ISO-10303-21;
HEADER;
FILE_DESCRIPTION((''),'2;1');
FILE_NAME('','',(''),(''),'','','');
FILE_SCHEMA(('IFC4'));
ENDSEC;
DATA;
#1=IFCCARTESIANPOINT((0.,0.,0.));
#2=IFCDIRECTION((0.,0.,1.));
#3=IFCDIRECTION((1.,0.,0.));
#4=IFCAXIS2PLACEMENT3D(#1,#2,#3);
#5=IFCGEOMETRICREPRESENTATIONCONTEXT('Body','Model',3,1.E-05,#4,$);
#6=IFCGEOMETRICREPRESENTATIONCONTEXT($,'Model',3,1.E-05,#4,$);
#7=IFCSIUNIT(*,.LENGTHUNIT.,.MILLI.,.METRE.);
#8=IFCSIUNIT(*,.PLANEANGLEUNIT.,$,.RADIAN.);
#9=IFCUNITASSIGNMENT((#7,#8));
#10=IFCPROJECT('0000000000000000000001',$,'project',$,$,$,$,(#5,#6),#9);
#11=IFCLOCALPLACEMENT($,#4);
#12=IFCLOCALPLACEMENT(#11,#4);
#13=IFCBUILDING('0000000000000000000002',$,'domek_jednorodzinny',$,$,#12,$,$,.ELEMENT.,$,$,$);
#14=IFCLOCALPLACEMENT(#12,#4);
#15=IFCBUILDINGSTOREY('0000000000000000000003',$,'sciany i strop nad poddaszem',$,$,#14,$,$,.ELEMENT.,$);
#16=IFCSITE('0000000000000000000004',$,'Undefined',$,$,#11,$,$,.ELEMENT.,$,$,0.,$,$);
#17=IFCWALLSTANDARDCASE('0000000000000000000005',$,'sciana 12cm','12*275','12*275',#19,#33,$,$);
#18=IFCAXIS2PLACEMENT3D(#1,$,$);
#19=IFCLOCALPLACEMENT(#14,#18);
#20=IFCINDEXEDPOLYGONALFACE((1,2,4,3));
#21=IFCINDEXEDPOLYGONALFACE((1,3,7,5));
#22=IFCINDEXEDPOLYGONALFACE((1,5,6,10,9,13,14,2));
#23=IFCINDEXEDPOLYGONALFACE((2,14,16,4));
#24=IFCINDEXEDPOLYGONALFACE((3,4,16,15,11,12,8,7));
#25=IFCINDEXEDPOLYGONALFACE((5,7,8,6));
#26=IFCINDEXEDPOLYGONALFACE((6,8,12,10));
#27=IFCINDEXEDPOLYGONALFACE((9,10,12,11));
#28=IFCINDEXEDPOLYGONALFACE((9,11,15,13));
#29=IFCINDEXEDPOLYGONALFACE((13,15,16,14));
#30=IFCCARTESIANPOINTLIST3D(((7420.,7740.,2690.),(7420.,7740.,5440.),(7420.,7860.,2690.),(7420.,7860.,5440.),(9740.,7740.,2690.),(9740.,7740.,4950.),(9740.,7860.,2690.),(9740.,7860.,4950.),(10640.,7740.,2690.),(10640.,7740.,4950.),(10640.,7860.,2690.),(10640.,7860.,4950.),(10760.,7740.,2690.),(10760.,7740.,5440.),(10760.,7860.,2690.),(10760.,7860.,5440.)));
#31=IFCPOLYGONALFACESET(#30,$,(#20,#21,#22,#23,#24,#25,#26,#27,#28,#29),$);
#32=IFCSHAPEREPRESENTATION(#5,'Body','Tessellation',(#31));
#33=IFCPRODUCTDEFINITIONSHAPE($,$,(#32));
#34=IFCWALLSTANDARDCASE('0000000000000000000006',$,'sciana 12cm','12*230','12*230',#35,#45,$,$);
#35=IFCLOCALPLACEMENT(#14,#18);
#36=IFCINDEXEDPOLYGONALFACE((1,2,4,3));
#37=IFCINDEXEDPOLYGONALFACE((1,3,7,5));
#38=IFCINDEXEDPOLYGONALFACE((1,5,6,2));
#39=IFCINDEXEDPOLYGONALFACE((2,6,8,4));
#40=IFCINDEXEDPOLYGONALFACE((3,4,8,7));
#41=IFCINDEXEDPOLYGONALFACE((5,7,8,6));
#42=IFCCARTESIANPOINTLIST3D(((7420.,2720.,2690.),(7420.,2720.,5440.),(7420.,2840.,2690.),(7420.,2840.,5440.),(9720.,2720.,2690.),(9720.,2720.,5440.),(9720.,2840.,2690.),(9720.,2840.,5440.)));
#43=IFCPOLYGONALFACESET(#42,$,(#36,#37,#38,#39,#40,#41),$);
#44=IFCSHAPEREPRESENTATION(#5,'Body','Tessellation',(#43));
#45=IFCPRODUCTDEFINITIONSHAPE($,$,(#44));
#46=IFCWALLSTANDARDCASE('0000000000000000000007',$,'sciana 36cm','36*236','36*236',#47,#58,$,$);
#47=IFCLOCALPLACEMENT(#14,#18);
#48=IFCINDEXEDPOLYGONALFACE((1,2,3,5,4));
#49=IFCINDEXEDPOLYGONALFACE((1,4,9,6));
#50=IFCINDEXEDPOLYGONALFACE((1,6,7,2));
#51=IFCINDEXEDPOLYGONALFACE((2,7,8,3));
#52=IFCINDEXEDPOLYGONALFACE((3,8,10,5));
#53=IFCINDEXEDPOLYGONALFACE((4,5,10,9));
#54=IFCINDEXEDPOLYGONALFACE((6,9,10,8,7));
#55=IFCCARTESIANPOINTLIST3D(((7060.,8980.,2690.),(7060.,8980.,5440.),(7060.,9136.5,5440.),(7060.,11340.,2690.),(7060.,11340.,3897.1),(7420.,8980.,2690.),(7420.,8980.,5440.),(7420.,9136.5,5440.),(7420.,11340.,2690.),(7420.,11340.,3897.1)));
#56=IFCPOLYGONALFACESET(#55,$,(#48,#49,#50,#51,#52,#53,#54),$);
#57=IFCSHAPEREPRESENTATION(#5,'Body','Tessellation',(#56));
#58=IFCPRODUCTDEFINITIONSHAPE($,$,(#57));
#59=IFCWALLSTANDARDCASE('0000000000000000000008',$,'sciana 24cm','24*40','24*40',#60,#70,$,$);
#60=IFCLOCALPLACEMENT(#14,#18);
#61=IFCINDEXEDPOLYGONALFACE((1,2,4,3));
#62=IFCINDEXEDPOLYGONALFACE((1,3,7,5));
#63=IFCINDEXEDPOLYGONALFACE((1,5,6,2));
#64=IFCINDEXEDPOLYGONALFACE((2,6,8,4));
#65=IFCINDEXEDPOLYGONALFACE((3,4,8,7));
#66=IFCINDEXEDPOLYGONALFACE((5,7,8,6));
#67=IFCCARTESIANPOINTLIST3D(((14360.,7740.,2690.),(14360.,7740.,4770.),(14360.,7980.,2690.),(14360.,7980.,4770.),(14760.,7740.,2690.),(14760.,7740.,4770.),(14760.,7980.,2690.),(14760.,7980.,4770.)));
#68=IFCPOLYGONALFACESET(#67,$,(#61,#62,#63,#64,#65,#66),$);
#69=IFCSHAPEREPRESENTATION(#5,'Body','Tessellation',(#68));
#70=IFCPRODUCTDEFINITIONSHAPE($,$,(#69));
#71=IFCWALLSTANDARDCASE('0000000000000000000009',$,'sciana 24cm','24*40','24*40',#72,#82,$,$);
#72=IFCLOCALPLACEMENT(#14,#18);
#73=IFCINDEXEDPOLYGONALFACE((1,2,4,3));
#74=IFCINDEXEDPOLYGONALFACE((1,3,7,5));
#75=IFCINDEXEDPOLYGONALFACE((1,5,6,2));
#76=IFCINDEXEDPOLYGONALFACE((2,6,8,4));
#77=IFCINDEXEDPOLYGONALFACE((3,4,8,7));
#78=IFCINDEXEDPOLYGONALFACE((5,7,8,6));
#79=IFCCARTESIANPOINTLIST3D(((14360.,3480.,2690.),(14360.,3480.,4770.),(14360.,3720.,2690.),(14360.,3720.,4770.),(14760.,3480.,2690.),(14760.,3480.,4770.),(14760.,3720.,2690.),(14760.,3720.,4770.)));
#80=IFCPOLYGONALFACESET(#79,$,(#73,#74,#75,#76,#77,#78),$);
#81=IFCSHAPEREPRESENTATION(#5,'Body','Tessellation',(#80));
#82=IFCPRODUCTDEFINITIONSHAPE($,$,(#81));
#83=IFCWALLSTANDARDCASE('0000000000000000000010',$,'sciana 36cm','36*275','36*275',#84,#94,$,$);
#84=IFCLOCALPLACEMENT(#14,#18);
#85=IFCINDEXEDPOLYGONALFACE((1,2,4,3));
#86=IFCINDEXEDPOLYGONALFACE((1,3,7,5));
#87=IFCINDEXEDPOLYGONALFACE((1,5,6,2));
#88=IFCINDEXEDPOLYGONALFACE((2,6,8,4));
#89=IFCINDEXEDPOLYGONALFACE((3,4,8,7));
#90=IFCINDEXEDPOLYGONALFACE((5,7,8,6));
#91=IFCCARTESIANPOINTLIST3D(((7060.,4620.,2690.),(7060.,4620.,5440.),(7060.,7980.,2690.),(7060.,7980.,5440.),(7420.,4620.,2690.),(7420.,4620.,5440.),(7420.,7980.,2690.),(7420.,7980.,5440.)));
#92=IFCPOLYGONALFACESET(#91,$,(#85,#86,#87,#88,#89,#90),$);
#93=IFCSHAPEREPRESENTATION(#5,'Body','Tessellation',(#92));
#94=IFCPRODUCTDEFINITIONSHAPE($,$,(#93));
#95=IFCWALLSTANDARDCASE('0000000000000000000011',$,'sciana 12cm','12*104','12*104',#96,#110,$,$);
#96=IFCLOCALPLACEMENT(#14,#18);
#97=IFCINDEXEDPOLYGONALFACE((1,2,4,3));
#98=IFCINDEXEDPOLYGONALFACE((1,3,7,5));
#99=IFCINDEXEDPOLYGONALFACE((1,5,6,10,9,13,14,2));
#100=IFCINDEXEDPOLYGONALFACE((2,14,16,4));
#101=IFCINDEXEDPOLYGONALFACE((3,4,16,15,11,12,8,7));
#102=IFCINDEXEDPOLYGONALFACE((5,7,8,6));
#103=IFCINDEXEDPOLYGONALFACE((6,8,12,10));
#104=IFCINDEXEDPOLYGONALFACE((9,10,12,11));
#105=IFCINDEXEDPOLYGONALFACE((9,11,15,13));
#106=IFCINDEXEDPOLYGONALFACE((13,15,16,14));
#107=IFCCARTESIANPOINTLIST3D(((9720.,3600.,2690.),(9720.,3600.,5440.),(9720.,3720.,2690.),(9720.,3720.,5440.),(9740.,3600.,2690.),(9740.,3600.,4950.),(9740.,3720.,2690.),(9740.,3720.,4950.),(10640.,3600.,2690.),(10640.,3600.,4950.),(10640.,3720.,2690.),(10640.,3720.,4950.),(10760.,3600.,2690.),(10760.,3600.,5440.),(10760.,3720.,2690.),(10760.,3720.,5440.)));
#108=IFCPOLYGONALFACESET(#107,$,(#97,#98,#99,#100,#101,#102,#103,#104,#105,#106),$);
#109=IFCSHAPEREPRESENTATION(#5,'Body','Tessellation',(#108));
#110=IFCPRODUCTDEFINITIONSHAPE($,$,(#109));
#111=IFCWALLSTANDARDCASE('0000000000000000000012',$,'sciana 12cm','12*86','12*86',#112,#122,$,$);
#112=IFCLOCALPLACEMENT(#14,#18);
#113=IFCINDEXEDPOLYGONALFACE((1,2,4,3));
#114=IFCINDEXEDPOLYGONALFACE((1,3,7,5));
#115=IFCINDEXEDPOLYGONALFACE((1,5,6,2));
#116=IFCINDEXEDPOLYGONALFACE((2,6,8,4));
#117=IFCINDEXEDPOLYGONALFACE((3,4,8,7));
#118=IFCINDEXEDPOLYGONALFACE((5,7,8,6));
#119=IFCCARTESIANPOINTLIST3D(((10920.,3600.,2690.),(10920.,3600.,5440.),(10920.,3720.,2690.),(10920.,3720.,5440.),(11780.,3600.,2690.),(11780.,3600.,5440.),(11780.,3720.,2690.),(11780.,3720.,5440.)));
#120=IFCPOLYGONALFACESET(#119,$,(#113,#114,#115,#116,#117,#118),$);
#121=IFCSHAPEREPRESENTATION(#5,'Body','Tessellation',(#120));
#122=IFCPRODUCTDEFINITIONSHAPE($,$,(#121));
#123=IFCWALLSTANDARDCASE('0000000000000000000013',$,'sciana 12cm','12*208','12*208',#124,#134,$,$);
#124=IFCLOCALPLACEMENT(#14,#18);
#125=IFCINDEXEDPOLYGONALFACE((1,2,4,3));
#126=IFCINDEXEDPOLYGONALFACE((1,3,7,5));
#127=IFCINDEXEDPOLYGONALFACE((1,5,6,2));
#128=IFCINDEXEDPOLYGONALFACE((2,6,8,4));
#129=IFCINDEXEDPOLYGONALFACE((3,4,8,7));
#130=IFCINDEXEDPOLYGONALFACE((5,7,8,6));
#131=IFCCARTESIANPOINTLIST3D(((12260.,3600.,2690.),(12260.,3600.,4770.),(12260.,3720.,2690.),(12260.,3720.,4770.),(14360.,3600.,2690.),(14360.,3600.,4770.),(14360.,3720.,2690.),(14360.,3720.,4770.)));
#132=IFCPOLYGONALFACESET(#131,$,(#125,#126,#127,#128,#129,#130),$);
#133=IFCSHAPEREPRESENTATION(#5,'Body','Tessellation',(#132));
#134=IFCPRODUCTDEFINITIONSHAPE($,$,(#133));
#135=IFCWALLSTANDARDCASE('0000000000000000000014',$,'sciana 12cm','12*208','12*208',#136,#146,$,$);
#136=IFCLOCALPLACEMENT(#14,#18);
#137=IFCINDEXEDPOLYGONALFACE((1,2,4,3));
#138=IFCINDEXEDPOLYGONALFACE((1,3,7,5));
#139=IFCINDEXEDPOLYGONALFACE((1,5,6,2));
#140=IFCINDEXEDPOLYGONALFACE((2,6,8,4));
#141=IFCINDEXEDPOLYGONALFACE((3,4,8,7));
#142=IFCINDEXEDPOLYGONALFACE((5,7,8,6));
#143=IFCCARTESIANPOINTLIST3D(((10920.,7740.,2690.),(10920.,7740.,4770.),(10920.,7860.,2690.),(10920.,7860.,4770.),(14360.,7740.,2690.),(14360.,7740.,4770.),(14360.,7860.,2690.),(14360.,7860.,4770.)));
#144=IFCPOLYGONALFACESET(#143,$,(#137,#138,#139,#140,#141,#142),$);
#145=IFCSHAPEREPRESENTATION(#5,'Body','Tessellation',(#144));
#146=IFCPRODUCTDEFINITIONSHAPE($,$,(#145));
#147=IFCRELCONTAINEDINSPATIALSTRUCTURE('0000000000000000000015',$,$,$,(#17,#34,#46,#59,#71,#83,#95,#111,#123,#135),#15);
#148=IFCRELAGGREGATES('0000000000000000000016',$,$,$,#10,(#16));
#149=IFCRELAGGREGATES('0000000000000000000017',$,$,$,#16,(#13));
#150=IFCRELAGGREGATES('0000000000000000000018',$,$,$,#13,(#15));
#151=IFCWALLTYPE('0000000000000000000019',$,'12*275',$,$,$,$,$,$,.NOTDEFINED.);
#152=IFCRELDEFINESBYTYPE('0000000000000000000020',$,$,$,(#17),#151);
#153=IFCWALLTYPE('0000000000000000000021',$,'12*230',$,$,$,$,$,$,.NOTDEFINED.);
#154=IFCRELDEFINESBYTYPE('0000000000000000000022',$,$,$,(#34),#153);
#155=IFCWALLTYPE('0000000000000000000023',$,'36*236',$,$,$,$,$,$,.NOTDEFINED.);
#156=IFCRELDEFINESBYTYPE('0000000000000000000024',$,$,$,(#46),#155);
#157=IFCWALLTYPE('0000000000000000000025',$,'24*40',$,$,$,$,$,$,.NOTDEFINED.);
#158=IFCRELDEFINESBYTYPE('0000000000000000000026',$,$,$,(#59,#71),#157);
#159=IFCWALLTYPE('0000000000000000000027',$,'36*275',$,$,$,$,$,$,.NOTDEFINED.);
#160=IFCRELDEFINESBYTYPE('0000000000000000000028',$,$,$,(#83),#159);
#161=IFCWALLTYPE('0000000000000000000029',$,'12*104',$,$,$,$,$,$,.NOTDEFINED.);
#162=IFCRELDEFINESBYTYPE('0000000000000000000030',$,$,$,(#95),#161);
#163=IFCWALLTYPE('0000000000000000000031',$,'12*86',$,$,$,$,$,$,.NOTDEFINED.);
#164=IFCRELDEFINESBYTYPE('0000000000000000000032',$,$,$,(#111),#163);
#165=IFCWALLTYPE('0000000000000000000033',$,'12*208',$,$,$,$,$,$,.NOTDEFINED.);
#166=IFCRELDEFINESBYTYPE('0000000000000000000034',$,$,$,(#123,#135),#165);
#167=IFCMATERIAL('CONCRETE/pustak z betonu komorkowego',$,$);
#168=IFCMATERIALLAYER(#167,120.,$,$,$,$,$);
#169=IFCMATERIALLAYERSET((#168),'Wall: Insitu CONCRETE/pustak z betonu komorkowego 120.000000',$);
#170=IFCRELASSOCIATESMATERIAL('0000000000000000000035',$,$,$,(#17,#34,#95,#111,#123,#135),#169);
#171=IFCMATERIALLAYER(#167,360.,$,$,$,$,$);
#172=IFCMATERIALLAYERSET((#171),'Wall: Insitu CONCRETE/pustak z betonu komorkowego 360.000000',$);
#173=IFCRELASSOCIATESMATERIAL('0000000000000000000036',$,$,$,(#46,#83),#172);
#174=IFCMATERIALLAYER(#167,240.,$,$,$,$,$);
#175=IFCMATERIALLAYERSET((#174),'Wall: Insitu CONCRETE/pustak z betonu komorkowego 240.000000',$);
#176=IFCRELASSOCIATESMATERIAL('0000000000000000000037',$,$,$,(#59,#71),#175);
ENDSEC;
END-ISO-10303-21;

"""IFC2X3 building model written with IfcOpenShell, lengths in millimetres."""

from ifc_helpers import new_model, si_unit, frame, frame_2d, origin_with_axes, place, context, project, spatial, polyline, rectangle, outline, extrude, clip, halfspace, material, layer, layer_set, layer_usage, type_object, element, save


model = new_model("IFC2X3")

# Units and contexts
model_context_1 = context("Model", 3, precision=1e-05, world=origin_with_axes(), identifier="Body")
model_context_2 = context("Model", 3, precision=1e-05, world=origin_with_axes())
ifc_project = project(units=[si_unit("LENGTHUNIT", "METRE", prefix="MILLI"), si_unit("PLANEANGLEUNIT", "RADIAN")], contexts=[model_context_1, model_context_2])

# Site, building, storey
site_placement = place(None, origin_with_axes())
site = spatial("IfcSite", under=ifc_project, at=site_placement, Name="Undefined", CompositionType="ELEMENT", RefElevation=0.0)
building_placement = place(site_placement, origin_with_axes())
building = spatial("IfcBuilding", under=site, at=building_placement, Name="domek_jednorodzinny", CompositionType="ELEMENT")
storey_placement = place(building_placement, origin_with_axes())
storey = spatial("IfcBuildingStorey", under=building, at=storey_placement, Name="sciany i strop nad poddaszem", CompositionType="ELEMENT")

# Shared definitions
ifc_material_1 = material(Name="CONCRETE/pustak z betonu komorkowego")
ifc_layer_1 = layer(ifc_material_1, 120.0)
ifc_layer_set_1 = layer_set([ifc_layer_1], Name="Wall: Insitu CONCRETE/pustak z betonu komorkowego 120.000000")
wall_type_1 = type_object("IfcWallType", Name="12*275", PredefinedType="NOTDEFINED")

# Wall, opening
ifc_layer_usage_1 = layer_usage(ifc_layer_set_1, "AXIS2", "POSITIVE", -60.0)
wall_1_placement = place(storey_placement, frame((7420.0, 7800.0, 2690.0), z_axis=(0.0, 0.0, 1.0), x_axis=(1.0, 0.0, 0.0)))
wall_1 = element("IfcWallStandardCase", 1, at=wall_1_placement, inside=storey, type_object=wall_type_1, material=ifc_layer_usage_1, Name="sciana 12cm", Description="12*275", ObjectType="12*275", context=model_context_1, shape_type="SweptSolid", body=[
    extrude(rectangle(XDim=3340.0, YDim=120.0, at=frame_2d((0.0, 1670.0), x_axis=(0.0, -1.0))), frame((0.0, 0.0, 0.0), z_axis=(0.0, 0.0, 1.0), x_axis=(0.0, -1.0, 0.0)), (0.0, 0.0, 1.0), 2750.0),
])
opening_1_placement = place(storey_placement, frame((7420.0, 7800.0, 2690.0), z_axis=(0.0, 0.0, 1.0), x_axis=(1.0, 0.0, 0.0)))
element("IfcOpeningElement", 2, at=opening_1_placement, cuts=wall_1, ObjectType="Recess", context=model_context_1, shape_type="SweptSolid", body=[
    extrude(outline(polyline([(0.0, 0.0), (900.0, 0.0), (900.0, 520.0), (0.0, 520.0), (0.0, 0.0)])), frame((3220.0, -260.0, 2260.0), z_axis=(0.000001, 0.000001, -1.0), x_axis=(-1.0, 0.0, 0.0)), (0.0, 0.0, 1.0), 2260.0),
])

# Walls
ifc_layer_usage_2 = layer_usage(ifc_layer_set_1, "AXIS2", "POSITIVE", -60.0)
wall_type_2 = type_object("IfcWallType", Name="12*230", PredefinedType="NOTDEFINED")
wall_2_placement = place(storey_placement, frame((7420.0, 2780.0, 2690.0), z_axis=(0.0, 0.0, 1.0), x_axis=(1.0, 0.0, 0.0)))
element("IfcWallStandardCase", 3, at=wall_2_placement, inside=storey, type_object=wall_type_2, material=ifc_layer_usage_2, Name="sciana 12cm", Description="12*230", ObjectType="12*230", context=model_context_1, shape_type="SweptSolid", body=[
    extrude(rectangle(XDim=2300.0, YDim=120.0, at=frame_2d((0.0, 1150.0), x_axis=(0.0, -1.0))), frame((0.0, 0.0, 0.0), z_axis=(0.0, 0.0, 1.0), x_axis=(0.0, -1.0, 0.0)), (0.0, 0.0, 1.0), 2750.0),
])
ifc_layer_2 = layer(ifc_material_1, 360.0)
ifc_layer_set_2 = layer_set([ifc_layer_2], Name="Wall: Insitu CONCRETE/pustak z betonu komorkowego 360.000000")
ifc_layer_usage_3 = layer_usage(ifc_layer_set_2, "AXIS2", "POSITIVE", -180.0)
wall_type_3 = type_object("IfcWallType", Name="36*236", PredefinedType="NOTDEFINED")
wall_3_placement = place(storey_placement, frame((7240.0, 8980.0, 2690.0), z_axis=(0.0, 0.0, 1.0), x_axis=(0.0, 1.0, 0.0)))
element("IfcWallStandardCase", 4, at=wall_3_placement, inside=storey, type_object=wall_type_3, material=ifc_layer_usage_3, Name="sciana 36cm", Description="36*236", ObjectType="36*236", context=model_context_1, shape_type="Clipping", body=[
    clip(extrude(rectangle(XDim=2360.0, YDim=360.0, at=frame_2d((0.0, 1180.0), x_axis=(0.0, -1.0))), frame((0.0, 0.0, 0.0), z_axis=(0.0, 0.0, 1.0), x_axis=(0.0, -1.0, 0.0)), (0.0, 0.0, 1.0), 2750.0), halfspace(frame((4119.6, -180.0, -25.0), z_axis=(0.573578, 0.0, 0.819151), x_axis=(-0.819152, 0.0, 0.573576)), False)),
])
ifc_layer_3 = layer(ifc_material_1, 240.0)
ifc_layer_set_3 = layer_set([ifc_layer_3], Name="Wall: Insitu CONCRETE/pustak z betonu komorkowego 240.000000")
ifc_layer_usage_4 = layer_usage(ifc_layer_set_3, "AXIS2", "POSITIVE", -120.0)
wall_type_4 = type_object("IfcWallType", Name="24*40", PredefinedType="NOTDEFINED")
wall_4_placement = place(storey_placement, frame((14360.0, 7860.0, 2690.0), z_axis=(0.0, 0.0, 1.0), x_axis=(1.0, 0.0, 0.0)))
element("IfcWallStandardCase", 5, at=wall_4_placement, inside=storey, type_object=wall_type_4, material=ifc_layer_usage_4, Name="sciana 24cm", Description="24*40", ObjectType="24*40", context=model_context_1, shape_type="SweptSolid", body=[
    extrude(rectangle(XDim=400.0, YDim=240.0, at=frame_2d((0.0, 200.0), x_axis=(0.0, -1.0))), frame((0.0, 0.0, 0.0), z_axis=(0.0, 0.0, 1.0), x_axis=(0.0, -1.0, 0.0)), (0.0, 0.0, 1.0), 2080.0),
])
ifc_layer_usage_5 = layer_usage(ifc_layer_set_3, "AXIS2", "POSITIVE", -120.0)
wall_5_placement = place(storey_placement, frame((14360.0, 3600.0, 2690.0), z_axis=(0.0, 0.0, 1.0), x_axis=(1.0, 0.0, 0.0)))
element("IfcWallStandardCase", 6, at=wall_5_placement, inside=storey, type_object=wall_type_4, material=ifc_layer_usage_5, Name="sciana 24cm", Description="24*40", ObjectType="24*40", context=model_context_1, shape_type="SweptSolid", body=[
    extrude(rectangle(XDim=400.0, YDim=240.0, at=frame_2d((0.0, 200.0), x_axis=(0.0, -1.0))), frame((0.0, 0.0, 0.0), z_axis=(0.0, 0.0, 1.0), x_axis=(0.0, -1.0, 0.0)), (0.0, 0.0, 1.0), 2080.0),
])
ifc_layer_usage_6 = layer_usage(ifc_layer_set_2, "AXIS2", "POSITIVE", -180.0)
wall_type_5 = type_object("IfcWallType", Name="36*275", PredefinedType="NOTDEFINED")
wall_6_placement = place(storey_placement, frame((7240.0, 4620.0, 2690.0), z_axis=(0.0, 0.0, 1.0), x_axis=(0.0, 1.0, 0.0)))
element("IfcWallStandardCase", 7, at=wall_6_placement, inside=storey, type_object=wall_type_5, material=ifc_layer_usage_6, Name="sciana 36cm", Description="36*275", ObjectType="36*275", context=model_context_1, shape_type="SweptSolid", body=[
    extrude(rectangle(XDim=3360.0, YDim=360.0, at=frame_2d((0.0, 1680.0), x_axis=(0.0, -1.0))), frame((0.0, 0.0, 0.0), z_axis=(0.0, 0.0, 1.0), x_axis=(0.0, -1.0, 0.0)), (0.0, 0.0, 1.0), 2750.0),
])

# Wall, opening
ifc_layer_usage_7 = layer_usage(ifc_layer_set_1, "AXIS2", "POSITIVE", -60.0)
wall_type_6 = type_object("IfcWallType", Name="12*104", PredefinedType="NOTDEFINED")
wall_7_placement = place(storey_placement, frame((10760.0, 3660.0, 2690.0), z_axis=(0.0, 0.0, 1.0), x_axis=(-1.0, 0.0, 0.0)))
wall_7 = element("IfcWallStandardCase", 8, at=wall_7_placement, inside=storey, type_object=wall_type_6, material=ifc_layer_usage_7, Name="sciana 12cm", Description="12*104", ObjectType="12*104", context=model_context_1, shape_type="SweptSolid", body=[
    extrude(rectangle(XDim=1040.0, YDim=120.0, at=frame_2d((0.0, 520.0), x_axis=(0.0, -1.0))), frame((0.0, 0.0, 0.0), z_axis=(0.0, 0.0, 1.0), x_axis=(0.0, -1.0, 0.0)), (0.0, 0.0, 1.0), 2750.0),
])
opening_2_placement = place(storey_placement, frame((10760.0, 3660.0, 2690.0), z_axis=(0.0, 0.0, 1.0), x_axis=(-1.0, 0.0, 0.0)))
element("IfcOpeningElement", 9, at=opening_2_placement, cuts=wall_7, ObjectType="Recess", context=model_context_1, shape_type="SweptSolid", body=[
    extrude(outline(polyline([(0.0, 0.0), (520.0, 0.0), (520.0, 900.0), (0.0, 900.0), (0.0, 0.0)])), frame((1020.0, 260.0, 2260.0), z_axis=(0.000001, 0.000001, -1.0), x_axis=(0.0, -1.0, 0.0)), (0.0, 0.0, 1.0), 2260.0),
])

# Walls
ifc_layer_usage_8 = layer_usage(ifc_layer_set_1, "AXIS2", "POSITIVE", -60.0)
wall_type_7 = type_object("IfcWallType", Name="12*86", PredefinedType="NOTDEFINED")
wall_8_placement = place(storey_placement, frame((11780.0, 3660.0, 2690.0), z_axis=(0.0, 0.0, 1.0), x_axis=(-1.0, 0.0, 0.0)))
element("IfcWallStandardCase", 10, at=wall_8_placement, inside=storey, type_object=wall_type_7, material=ifc_layer_usage_8, Name="sciana 12cm", Description="12*86", ObjectType="12*86", context=model_context_1, shape_type="SweptSolid", body=[
    extrude(rectangle(XDim=860.0, YDim=120.0, at=frame_2d((0.0, 430.0), x_axis=(0.0, -1.0))), frame((0.0, 0.0, 0.0), z_axis=(0.0, 0.0, 1.0), x_axis=(0.0, -1.0, 0.0)), (0.0, 0.0, 1.0), 2750.0),
])
ifc_layer_usage_9 = layer_usage(ifc_layer_set_1, "AXIS2", "POSITIVE", -60.0)
wall_type_8 = type_object("IfcWallType", Name="12*208", PredefinedType="NOTDEFINED")
wall_9_placement = place(storey_placement, frame((14360.0, 3660.0, 2690.0), z_axis=(0.0, 0.0, 1.0), x_axis=(-1.0, 0.0, 0.0)))
element("IfcWallStandardCase", 11, at=wall_9_placement, inside=storey, type_object=wall_type_8, material=ifc_layer_usage_9, Name="sciana 12cm", Description="12*208", ObjectType="12*208", context=model_context_1, shape_type="SweptSolid", body=[
    extrude(rectangle(XDim=2100.0, YDim=120.0, at=frame_2d((0.0, 1050.0), x_axis=(0.0, -1.0))), frame((0.0, 0.0, 0.0), z_axis=(0.0, 0.0, 1.0), x_axis=(0.0, -1.0, 0.0)), (0.0, 0.0, 1.0), 2080.0),
])
ifc_layer_usage_10 = layer_usage(ifc_layer_set_1, "AXIS2", "POSITIVE", -60.0)
wall_10_placement = place(storey_placement, frame((10920.0, 7800.0, 2690.0), z_axis=(0.0, 0.0, 1.0), x_axis=(1.0, 0.0, 0.0)))
element("IfcWallStandardCase", 12, at=wall_10_placement, inside=storey, type_object=wall_type_8, material=ifc_layer_usage_10, Name="sciana 12cm", Description="12*208", ObjectType="12*208", context=model_context_1, shape_type="SweptSolid", body=[
    extrude(rectangle(XDim=3440.0, YDim=120.0, at=frame_2d((0.0, 1720.0), x_axis=(0.0, -1.0))), frame((0.0, 0.0, 0.0), z_axis=(0.0, 0.0, 1.0), x_axis=(0.0, -1.0, 0.0)), (0.0, 0.0, 1.0), 2080.0),
])

save(model, "model.ifc")
